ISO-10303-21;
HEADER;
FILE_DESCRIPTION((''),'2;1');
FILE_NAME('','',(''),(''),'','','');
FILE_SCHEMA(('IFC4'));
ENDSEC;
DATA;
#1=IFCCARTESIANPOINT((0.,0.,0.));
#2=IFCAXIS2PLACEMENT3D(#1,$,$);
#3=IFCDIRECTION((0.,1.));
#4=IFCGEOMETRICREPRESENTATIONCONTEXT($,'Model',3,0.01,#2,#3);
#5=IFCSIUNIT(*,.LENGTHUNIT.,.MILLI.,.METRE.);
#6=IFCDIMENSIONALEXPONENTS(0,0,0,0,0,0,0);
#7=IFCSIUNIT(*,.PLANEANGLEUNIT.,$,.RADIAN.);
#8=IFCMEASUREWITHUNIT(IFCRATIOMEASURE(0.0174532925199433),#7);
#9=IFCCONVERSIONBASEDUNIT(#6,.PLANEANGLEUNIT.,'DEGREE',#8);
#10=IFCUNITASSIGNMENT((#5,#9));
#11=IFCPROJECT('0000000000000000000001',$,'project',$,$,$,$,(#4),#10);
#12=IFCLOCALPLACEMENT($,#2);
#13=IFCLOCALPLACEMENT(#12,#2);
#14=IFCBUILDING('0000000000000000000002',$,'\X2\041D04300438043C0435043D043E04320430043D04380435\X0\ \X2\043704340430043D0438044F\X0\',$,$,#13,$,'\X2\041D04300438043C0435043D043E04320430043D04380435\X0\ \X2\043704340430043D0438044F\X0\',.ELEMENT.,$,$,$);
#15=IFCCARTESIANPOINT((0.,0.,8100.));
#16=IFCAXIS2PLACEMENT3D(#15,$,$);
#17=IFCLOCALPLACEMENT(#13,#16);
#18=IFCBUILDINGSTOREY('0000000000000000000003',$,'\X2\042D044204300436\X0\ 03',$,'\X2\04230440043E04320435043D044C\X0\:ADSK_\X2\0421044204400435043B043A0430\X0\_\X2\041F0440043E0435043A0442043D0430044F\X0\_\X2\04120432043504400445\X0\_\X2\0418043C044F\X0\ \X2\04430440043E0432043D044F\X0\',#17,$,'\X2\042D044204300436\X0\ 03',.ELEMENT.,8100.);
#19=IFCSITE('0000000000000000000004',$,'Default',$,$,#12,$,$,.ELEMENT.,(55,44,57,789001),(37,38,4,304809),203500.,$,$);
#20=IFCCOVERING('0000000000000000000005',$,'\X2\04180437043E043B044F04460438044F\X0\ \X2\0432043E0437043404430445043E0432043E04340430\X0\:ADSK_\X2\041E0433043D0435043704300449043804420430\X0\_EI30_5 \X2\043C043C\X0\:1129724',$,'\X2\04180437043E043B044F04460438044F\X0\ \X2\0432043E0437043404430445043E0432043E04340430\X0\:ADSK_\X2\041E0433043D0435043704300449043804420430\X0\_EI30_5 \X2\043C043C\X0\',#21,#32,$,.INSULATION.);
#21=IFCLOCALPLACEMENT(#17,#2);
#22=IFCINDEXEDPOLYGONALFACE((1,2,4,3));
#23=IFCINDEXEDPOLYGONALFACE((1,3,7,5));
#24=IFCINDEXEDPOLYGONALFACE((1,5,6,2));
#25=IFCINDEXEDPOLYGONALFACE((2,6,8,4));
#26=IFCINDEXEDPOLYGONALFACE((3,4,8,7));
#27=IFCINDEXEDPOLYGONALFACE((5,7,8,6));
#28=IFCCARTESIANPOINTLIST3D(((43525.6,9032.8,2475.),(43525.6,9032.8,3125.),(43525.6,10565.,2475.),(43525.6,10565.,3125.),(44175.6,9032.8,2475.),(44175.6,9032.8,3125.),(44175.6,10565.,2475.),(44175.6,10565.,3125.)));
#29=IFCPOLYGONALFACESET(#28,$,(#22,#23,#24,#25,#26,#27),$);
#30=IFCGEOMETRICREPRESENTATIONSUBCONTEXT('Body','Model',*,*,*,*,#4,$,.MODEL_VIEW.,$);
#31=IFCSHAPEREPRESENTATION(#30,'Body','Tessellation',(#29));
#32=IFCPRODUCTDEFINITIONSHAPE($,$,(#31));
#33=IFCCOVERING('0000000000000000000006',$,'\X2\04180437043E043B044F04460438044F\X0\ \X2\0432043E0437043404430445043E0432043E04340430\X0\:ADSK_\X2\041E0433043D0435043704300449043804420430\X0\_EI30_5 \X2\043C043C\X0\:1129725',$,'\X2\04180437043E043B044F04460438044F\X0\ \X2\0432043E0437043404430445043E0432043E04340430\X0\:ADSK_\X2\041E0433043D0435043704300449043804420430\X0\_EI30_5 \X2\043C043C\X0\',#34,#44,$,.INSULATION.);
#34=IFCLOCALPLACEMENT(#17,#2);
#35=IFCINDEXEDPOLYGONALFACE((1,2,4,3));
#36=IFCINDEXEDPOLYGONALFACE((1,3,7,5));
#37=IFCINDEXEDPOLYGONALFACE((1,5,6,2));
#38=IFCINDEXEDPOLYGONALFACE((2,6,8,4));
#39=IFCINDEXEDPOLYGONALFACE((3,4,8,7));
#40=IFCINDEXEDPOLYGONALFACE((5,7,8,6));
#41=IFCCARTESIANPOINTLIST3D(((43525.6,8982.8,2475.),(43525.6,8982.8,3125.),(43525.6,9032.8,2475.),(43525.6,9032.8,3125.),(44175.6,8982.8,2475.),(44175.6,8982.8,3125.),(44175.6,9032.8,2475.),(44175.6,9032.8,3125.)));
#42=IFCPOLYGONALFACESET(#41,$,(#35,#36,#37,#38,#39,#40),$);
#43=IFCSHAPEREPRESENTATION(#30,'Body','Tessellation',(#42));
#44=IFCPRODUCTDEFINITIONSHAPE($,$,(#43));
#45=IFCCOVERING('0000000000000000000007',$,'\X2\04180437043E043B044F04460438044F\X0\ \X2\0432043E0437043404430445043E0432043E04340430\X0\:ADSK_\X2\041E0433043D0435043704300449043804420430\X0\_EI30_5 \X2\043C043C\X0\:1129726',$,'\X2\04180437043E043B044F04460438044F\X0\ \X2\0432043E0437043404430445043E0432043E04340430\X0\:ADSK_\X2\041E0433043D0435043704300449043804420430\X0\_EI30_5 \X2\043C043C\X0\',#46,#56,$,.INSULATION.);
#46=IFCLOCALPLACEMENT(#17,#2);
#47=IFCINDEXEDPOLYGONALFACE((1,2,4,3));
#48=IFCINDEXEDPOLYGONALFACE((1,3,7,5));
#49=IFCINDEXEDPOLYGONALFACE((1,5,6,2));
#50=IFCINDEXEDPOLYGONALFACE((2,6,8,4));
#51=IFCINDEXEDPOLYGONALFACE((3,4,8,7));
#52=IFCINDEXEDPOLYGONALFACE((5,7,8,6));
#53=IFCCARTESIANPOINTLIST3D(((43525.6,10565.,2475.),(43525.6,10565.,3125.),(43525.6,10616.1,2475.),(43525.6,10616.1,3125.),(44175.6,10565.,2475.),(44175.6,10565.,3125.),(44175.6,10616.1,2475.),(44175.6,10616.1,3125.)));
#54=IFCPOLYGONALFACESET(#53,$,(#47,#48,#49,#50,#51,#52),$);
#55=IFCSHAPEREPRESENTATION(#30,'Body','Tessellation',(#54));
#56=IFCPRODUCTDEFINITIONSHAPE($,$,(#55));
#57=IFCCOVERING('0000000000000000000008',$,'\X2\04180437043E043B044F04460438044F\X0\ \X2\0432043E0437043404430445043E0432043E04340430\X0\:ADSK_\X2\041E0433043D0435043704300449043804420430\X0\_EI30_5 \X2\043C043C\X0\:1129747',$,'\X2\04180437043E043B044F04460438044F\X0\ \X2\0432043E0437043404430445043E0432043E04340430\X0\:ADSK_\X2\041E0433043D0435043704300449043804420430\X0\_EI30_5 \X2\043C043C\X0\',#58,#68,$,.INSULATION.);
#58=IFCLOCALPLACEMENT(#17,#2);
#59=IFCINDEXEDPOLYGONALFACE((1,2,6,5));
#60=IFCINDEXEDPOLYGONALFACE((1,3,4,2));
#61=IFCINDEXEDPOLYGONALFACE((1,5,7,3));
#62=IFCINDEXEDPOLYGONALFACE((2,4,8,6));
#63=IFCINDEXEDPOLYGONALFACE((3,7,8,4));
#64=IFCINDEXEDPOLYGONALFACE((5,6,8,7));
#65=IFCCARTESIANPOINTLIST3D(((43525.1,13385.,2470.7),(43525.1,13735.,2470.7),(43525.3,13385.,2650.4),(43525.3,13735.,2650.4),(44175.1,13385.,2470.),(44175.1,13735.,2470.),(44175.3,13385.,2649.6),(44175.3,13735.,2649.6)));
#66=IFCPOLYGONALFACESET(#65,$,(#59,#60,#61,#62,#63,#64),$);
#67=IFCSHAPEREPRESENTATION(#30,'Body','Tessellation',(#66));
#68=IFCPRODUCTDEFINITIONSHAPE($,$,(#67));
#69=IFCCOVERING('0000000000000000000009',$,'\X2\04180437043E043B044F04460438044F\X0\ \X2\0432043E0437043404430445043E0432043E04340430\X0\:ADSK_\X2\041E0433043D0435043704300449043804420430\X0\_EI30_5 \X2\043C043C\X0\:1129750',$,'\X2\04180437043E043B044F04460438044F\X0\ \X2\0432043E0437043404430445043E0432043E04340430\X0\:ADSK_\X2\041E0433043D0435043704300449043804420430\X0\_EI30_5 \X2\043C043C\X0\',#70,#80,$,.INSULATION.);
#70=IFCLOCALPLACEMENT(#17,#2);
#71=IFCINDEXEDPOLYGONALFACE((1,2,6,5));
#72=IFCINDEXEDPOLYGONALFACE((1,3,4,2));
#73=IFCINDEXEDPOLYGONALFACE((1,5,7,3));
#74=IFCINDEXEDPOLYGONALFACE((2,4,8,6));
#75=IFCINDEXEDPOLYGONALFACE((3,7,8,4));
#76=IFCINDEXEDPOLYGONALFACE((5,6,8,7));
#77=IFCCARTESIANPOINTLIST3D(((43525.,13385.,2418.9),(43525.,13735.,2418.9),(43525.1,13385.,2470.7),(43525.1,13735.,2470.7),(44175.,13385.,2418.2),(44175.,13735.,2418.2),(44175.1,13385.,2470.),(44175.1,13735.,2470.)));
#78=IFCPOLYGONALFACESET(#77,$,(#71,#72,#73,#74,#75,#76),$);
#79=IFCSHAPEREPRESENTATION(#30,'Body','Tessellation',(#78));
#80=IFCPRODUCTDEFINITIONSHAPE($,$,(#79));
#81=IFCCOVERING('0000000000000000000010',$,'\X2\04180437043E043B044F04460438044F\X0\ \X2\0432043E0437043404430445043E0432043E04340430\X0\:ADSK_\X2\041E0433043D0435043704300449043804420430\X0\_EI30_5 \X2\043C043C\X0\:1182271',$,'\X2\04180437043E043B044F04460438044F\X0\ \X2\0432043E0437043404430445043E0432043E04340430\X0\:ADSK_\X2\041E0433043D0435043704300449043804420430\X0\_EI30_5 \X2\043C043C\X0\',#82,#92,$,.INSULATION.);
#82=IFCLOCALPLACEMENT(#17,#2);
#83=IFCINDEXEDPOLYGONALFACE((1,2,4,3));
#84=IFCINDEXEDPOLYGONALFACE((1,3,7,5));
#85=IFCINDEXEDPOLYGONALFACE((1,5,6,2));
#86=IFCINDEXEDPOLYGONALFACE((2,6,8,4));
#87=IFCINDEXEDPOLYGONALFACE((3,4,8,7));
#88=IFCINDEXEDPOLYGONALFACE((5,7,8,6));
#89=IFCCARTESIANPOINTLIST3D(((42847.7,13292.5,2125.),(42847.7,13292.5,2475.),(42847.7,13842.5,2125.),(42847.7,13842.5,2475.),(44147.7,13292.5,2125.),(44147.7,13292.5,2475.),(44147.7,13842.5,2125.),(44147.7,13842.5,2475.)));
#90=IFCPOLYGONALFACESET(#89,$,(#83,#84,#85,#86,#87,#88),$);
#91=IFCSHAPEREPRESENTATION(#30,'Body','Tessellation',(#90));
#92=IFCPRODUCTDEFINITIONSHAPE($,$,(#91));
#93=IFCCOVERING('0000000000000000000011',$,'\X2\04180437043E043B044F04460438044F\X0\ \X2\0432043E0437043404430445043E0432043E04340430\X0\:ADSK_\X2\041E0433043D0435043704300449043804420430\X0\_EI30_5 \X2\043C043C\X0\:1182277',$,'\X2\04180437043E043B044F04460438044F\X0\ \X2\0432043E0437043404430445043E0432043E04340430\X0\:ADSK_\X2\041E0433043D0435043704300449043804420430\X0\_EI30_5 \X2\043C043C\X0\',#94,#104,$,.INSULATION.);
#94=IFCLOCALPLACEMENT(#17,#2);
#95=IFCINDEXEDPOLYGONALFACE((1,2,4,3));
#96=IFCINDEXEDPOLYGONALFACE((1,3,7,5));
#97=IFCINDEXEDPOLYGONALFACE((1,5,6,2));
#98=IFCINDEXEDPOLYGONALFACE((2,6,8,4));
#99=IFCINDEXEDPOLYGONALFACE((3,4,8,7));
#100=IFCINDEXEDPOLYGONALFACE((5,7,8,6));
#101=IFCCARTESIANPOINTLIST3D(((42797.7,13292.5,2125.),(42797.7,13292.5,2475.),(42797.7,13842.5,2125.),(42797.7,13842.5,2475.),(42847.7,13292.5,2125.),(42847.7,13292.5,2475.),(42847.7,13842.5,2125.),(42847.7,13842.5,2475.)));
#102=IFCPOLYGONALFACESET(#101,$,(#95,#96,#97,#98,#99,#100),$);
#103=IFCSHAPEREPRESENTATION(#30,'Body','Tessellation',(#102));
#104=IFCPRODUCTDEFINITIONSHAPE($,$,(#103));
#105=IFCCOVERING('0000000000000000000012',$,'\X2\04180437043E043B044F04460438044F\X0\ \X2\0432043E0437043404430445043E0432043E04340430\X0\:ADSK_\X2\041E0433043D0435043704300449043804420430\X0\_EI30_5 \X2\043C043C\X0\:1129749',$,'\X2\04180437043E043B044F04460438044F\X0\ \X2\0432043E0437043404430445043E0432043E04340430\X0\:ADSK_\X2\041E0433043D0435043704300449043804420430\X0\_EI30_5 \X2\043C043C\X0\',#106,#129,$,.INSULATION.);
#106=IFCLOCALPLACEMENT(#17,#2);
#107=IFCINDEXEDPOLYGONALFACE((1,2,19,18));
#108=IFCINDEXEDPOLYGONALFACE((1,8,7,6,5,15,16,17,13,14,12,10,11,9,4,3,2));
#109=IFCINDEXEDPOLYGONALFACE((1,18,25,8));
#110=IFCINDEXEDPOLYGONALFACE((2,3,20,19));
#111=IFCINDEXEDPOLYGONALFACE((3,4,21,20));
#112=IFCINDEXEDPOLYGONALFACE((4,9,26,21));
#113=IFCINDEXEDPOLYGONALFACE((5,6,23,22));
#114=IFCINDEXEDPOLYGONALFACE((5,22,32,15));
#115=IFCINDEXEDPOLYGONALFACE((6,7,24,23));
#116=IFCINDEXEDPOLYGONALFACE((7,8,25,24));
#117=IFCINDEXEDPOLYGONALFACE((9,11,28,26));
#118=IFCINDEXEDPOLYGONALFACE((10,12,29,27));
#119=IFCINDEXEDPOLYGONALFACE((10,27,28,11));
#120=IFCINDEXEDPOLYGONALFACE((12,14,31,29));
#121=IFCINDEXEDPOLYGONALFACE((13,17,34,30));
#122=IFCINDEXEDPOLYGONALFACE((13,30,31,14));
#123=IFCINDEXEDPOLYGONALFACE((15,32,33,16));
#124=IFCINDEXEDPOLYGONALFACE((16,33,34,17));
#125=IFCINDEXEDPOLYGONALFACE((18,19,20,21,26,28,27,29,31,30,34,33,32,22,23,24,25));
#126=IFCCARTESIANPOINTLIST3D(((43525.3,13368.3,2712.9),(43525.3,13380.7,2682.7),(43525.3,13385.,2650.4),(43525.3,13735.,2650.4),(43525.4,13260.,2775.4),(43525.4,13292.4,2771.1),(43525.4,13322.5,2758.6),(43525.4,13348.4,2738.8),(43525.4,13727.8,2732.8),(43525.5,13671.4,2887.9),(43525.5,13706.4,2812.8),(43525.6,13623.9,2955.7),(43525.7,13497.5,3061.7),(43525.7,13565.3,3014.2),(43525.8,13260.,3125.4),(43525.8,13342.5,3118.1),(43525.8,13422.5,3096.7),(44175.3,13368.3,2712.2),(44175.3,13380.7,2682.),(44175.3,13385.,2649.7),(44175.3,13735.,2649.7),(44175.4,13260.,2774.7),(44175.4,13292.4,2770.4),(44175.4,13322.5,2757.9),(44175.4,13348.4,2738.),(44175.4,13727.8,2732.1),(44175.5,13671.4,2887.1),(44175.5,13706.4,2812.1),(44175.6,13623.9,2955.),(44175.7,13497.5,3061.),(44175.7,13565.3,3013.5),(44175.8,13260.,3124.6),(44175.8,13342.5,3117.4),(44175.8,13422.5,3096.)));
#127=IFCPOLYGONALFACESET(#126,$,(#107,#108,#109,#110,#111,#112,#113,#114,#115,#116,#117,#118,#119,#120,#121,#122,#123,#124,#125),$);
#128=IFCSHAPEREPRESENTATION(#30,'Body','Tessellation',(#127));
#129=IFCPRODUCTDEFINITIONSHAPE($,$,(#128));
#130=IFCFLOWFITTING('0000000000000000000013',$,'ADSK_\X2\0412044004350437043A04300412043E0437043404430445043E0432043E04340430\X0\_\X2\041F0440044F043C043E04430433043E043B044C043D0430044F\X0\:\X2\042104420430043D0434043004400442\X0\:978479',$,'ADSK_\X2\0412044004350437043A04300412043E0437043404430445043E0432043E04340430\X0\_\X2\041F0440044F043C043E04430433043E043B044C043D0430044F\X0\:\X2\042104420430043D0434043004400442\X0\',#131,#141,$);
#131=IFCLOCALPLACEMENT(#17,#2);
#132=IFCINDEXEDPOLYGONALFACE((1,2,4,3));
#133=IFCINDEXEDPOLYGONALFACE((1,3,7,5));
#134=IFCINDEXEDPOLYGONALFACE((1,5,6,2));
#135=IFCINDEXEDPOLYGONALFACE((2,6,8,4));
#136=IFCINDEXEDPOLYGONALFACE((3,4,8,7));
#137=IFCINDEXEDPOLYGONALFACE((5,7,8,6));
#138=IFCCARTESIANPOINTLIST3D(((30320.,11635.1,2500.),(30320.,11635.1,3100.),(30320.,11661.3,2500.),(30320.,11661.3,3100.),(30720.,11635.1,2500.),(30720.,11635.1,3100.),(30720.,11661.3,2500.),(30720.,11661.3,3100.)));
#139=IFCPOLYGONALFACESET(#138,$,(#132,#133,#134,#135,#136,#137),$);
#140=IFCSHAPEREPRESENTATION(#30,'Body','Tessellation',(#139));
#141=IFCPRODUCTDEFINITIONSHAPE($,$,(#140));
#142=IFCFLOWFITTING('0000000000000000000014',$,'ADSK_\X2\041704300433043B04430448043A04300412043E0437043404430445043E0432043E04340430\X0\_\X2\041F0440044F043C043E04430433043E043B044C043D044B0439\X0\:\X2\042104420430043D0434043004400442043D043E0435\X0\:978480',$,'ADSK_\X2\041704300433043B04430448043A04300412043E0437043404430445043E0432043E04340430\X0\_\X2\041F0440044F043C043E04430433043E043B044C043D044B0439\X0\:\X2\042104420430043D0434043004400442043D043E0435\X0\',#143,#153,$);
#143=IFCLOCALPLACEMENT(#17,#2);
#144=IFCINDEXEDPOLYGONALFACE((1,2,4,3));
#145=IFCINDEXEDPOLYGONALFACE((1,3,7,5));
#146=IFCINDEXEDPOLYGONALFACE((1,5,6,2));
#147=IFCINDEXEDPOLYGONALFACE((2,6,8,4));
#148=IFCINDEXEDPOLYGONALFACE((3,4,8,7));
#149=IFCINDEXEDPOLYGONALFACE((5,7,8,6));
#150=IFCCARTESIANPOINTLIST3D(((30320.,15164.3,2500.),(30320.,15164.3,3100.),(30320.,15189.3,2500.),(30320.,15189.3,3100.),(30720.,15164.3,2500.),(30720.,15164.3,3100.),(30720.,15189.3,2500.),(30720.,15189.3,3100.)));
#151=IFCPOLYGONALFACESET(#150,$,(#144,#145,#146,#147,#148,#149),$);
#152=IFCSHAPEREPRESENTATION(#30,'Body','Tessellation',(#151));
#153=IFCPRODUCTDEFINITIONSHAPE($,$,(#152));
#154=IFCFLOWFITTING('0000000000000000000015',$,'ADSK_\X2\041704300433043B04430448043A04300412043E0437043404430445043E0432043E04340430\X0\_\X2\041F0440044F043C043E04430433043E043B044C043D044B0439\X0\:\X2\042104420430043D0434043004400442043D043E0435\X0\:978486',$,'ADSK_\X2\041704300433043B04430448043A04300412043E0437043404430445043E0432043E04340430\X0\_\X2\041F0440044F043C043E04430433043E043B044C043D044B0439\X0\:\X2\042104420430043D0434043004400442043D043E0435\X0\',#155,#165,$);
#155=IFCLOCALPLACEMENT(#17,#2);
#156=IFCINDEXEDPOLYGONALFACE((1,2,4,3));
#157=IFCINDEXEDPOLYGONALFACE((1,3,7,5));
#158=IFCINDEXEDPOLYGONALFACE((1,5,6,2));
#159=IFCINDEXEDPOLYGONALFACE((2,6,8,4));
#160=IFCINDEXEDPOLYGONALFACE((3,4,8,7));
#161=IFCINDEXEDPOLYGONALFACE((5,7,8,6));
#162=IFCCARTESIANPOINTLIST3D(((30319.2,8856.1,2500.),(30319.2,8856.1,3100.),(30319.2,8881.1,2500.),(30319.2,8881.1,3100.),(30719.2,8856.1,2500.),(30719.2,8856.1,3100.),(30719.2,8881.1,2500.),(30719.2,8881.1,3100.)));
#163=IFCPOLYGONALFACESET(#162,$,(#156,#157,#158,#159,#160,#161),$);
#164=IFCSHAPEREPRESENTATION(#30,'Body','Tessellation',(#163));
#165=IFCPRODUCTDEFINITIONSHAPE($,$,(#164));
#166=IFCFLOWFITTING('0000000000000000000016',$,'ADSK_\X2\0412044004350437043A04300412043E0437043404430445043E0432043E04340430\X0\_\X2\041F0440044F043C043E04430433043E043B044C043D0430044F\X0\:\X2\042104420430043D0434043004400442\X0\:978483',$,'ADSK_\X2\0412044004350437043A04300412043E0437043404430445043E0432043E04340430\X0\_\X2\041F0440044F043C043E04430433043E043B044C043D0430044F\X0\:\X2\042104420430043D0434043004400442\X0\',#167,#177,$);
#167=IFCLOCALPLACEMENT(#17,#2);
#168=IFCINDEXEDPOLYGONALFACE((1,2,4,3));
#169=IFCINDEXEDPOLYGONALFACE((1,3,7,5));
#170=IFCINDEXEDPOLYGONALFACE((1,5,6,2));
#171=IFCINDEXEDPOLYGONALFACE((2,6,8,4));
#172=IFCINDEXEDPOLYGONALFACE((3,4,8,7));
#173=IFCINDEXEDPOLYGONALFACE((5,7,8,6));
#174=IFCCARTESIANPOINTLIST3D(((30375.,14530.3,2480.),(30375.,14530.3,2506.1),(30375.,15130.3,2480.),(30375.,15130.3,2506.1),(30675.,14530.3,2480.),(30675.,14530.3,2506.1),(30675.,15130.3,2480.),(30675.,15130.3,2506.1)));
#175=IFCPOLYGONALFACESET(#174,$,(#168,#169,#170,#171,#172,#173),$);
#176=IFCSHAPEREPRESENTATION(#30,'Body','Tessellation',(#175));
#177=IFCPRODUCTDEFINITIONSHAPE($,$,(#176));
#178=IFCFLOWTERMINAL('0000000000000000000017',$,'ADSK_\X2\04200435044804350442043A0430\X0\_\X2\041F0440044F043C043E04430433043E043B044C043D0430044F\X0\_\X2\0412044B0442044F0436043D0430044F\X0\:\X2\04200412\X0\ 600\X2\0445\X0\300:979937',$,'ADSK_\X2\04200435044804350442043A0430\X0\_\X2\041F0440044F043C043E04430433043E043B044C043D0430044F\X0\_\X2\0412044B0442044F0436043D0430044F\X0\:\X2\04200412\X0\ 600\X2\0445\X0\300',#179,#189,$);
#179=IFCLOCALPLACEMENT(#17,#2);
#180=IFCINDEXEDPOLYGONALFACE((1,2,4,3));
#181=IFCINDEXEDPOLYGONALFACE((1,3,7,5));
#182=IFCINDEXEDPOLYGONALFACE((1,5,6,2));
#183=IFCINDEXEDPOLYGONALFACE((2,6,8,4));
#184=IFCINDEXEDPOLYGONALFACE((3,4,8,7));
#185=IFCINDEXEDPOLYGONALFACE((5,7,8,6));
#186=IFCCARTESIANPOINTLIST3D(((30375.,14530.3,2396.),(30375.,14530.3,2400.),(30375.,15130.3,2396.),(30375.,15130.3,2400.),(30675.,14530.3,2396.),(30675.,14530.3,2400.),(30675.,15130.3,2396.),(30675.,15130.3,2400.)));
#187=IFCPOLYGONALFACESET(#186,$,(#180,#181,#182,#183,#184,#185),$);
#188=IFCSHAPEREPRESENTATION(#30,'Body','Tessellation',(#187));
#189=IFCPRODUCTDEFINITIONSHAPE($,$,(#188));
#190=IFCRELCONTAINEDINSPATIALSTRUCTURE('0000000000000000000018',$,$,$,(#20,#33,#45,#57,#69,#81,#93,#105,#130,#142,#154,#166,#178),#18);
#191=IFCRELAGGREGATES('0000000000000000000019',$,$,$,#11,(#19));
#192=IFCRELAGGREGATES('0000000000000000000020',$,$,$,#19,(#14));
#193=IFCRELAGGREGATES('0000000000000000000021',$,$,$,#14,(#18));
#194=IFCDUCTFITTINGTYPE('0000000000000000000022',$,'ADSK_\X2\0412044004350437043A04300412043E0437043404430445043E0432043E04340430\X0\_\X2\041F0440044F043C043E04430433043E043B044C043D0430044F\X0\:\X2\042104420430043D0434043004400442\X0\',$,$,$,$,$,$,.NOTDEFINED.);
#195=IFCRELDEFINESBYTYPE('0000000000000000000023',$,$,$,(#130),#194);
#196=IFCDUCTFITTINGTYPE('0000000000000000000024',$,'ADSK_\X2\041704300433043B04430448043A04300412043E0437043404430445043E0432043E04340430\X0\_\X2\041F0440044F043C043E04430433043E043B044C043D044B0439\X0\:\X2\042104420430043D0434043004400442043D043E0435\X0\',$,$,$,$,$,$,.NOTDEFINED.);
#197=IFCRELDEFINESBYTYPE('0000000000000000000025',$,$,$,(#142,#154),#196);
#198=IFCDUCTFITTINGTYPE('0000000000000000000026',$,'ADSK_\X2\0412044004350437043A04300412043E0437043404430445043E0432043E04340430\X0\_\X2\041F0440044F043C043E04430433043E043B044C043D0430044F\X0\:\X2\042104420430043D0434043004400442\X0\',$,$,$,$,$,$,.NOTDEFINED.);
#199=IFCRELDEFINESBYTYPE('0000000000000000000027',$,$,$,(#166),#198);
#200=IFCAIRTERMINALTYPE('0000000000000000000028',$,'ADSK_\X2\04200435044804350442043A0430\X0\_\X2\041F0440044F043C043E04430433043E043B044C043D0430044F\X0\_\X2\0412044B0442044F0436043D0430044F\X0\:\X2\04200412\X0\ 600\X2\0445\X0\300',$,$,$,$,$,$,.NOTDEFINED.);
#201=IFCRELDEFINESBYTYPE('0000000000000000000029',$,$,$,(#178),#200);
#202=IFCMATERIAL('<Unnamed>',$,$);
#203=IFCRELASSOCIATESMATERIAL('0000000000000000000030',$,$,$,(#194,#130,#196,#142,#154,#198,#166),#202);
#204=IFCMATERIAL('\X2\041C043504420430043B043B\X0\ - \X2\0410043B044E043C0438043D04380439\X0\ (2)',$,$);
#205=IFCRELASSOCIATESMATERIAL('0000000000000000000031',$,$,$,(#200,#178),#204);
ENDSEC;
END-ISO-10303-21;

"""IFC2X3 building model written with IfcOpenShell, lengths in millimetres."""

from ifc_helpers import new_model, entity, si_unit, converted_unit, direction, frame, frame_2d, origin, origin_2d_with_axis, place, context, subcontext, project, spatial, polyline, circle_curve, parameter, trimmed, segment, composite_curve, rectangle, outline, extrude, source, transform, mapped, material, type_object, type_shapes, element, save


model = new_model("IFC2X3")

# Units and contexts
model_context = context("Model", 3, precision=0.01, world=origin(), true_north=direction((0.0, 1.0)))
body_context = subcontext(model_context, "Body", "Model", "MODEL_VIEW")
ifc_project = project(units=[si_unit("LENGTHUNIT", "METRE", prefix="MILLI"), converted_unit("PLANEANGLEUNIT", "DEGREE", entity("IfcRatioMeasure", 0.0174532925199433), si_unit("PLANEANGLEUNIT", "RADIAN"), dimensions=[0, 0, 0, 0, 0, 0, 0])], contexts=[model_context])

# Site, building, storey
site_placement = place(None, origin())
site = spatial("IfcSite", under=ifc_project, at=site_placement, Name="Default", CompositionType="ELEMENT", RefLatitude=(55, 44, 57, 789001), RefLongitude=(37, 38, 4, 304809), RefElevation=203500.0)
building_placement = place(site_placement, origin())
building = spatial("IfcBuilding", under=site, at=building_placement, Name="Наименование здания", LongName="Наименование здания", CompositionType="ELEMENT")
storey_placement = place(building_placement, frame((0.0, 0.0, 8100.0)))
storey = spatial("IfcBuildingStorey", under=building, at=storey_placement, Name="Этаж 03", ObjectType="Уровень:ADSK_Стрелка_Проектная_Вверх_Имя уровня", LongName="Этаж 03", CompositionType="ELEMENT", Elevation=8100.0)

# Coverings
covering_1_placement = place(storey_placement, frame((43525.6, 9032.8, 2475.0)))
element("IfcCovering", 1, at=covering_1_placement, inside=storey, Name="Изоляция воздуховода:ADSK_Огнезащита_EI30_5 мм:1129724", ObjectType="Изоляция воздуховода:ADSK_Огнезащита_EI30_5 мм", PredefinedType="INSULATION", context=body_context, shape_type="SweptSolid", body=[
    extrude(rectangle(XDim=1532.2, YDim=650.0, at=origin_2d_with_axis()), frame((325.0, 766.1, 0.0), z_axis=(0.0, 0.0, 1.0), x_axis=(0.0, 1.0, 0.0)), (0.0, 0.0, 1.0), 650.0),
])
covering_2_placement = place(storey_placement, frame((43525.6, 8982.8, 2475.0)))
element("IfcCovering", 2, at=covering_2_placement, inside=storey, Name="Изоляция воздуховода:ADSK_Огнезащита_EI30_5 мм:1129725", ObjectType="Изоляция воздуховода:ADSK_Огнезащита_EI30_5 мм", PredefinedType="INSULATION", context=body_context, shape_type="SweptSolid", body=[
    extrude(rectangle(XDim=50.0, YDim=650.0, at=origin_2d_with_axis()), frame((325.0, 25.0, 0.0), z_axis=(0.0, 0.0, 1.0), x_axis=(0.0, 1.0, 0.0)), (0.0, 0.0, 1.0), 650.0),
])
covering_3_placement = place(storey_placement, frame((43525.6, 10565.0, 2475.0)))
element("IfcCovering", 3, at=covering_3_placement, inside=storey, Name="Изоляция воздуховода:ADSK_Огнезащита_EI30_5 мм:1129726", ObjectType="Изоляция воздуховода:ADSK_Огнезащита_EI30_5 мм", PredefinedType="INSULATION", context=body_context, shape_type="SweptSolid", body=[
    extrude(rectangle(XDim=650.0, YDim=51.1, at=origin_2d_with_axis()), frame((325.0, 25.6, 0.0)), (0.0, 0.0, 1.0), 650.0),
])
covering_4_placement = place(storey_placement, frame((43525.1, 13385.0, 2470.0)))
element("IfcCovering", 4, at=covering_4_placement, inside=storey, Name="Изоляция воздуховода:ADSK_Огнезащита_EI30_5 мм:1129747", ObjectType="Изоляция воздуховода:ADSK_Огнезащита_EI30_5 мм", PredefinedType="INSULATION", context=body_context, shape_type="SweptSolid", body=[
    extrude(rectangle(XDim=650.0, YDim=350.0, at=origin_2d_with_axis()), frame((325.0, 175.0, 0.4), z_axis=(0.0011, 0.0, 0.999999), x_axis=(-0.999999, 0.0, 0.0011)), (0.0, 0.0, 1.0), 179.7),
])
covering_5_placement = place(storey_placement, frame((43525.0, 13385.0, 2418.2)))
element("IfcCovering", 5, at=covering_5_placement, inside=storey, Name="Изоляция воздуховода:ADSK_Огнезащита_EI30_5 мм:1129750", ObjectType="Изоляция воздуховода:ADSK_Огнезащита_EI30_5 мм", PredefinedType="INSULATION", context=body_context, shape_type="SweptSolid", body=[
    extrude(rectangle(XDim=650.0, YDim=350.0, at=frame_2d((0.0, 0.0), x_axis=(0.0, 1.0))), frame((325.0, 175.0, 0.4), z_axis=(0.0011, 0.0, 0.999999), x_axis=(0.0, -1.0, 0.0)), (0.0, 0.0, 1.0), 51.8),
])
covering_6_placement = place(storey_placement, frame((42847.7, 13292.5, 2125.0)))
element("IfcCovering", 6, at=covering_6_placement, inside=storey, Name="Изоляция воздуховода:ADSK_Огнезащита_EI30_5 мм:1182271", ObjectType="Изоляция воздуховода:ADSK_Огнезащита_EI30_5 мм", PredefinedType="INSULATION", context=body_context, shape_type="SweptSolid", body=[
    extrude(rectangle(XDim=1300.0, YDim=550.0, at=origin_2d_with_axis()), frame((650.0, 275.0, 0.0), z_axis=(0.0, 0.0, 1.0), x_axis=(-1.0, 0.0, 0.0)), (0.0, 0.0, 1.0), 350.0),
])
covering_7_placement = place(storey_placement, frame((42797.7, 13292.5, 2125.0)))
element("IfcCovering", 7, at=covering_7_placement, inside=storey, Name="Изоляция воздуховода:ADSK_Огнезащита_EI30_5 мм:1182277", ObjectType="Изоляция воздуховода:ADSK_Огнезащита_EI30_5 мм", PredefinedType="INSULATION", context=body_context, shape_type="SweptSolid", body=[
    extrude(rectangle(XDim=50.0, YDim=550.0, at=origin_2d_with_axis()), frame((25.0, 275.0, 0.0)), (0.0, 0.0, 1.0), 350.0),
])
covering_8_placement = place(storey_placement, frame((43523.7, 13258.4, 2648.1)))
element("IfcCovering", 8, at=covering_8_placement, inside=storey, Name="Изоляция воздуховода:ADSK_Огнезащита_EI30_5 мм:1129749", ObjectType="Изоляция воздуховода:ADSK_Огнезащита_EI30_5 мм", PredefinedType="INSULATION", context=body_context, shape_type="SweptSolid", body=[
    extrude(outline(composite_curve([segment(polyline([(-150.0, 25.0), (-150.0, -325.0)]), True, "CONTINUOUS"), segment(trimmed(circle_curve(frame_2d((-150.0, 150.0), x_axis=(1.0, 0.0)), 475.0), [parameter(270.0)], [parameter(0.0)], True, "PARAMETER"), True, "CONTINUOUS"), segment(polyline([(325.0, 150.0), (-25.0, 150.0)]), True, "CONTINUOUS"), segment(trimmed(circle_curve(frame_2d((-150.0, 150.0), x_axis=(1.0, 0.0)), 125.0), [parameter(270.0)], [parameter(360.0)], True, "PARAMETER"), False, "CONTINUOUS")], self_intersect=False)), frame((651.8, 151.6, 151.6), z_axis=(0.999999, 0.0, -0.0011), x_axis=(0.0011, 0.0, 0.999999)), (0.0, 0.0, -1.0), 650.0),
])

# Flow fittings
ifc_material_1 = material(Name="<Unnamed>")
duct_fitting_type_1 = type_object("IfcDuctFittingType", Name="ADSK_ВрезкаВоздуховода_Прямоугольная:Стандарт", PredefinedType="NOTDEFINED", material=ifc_material_1)
shared_shape_1 = source(origin(), body_context, "Body", "SweptSolid", [
    extrude(rectangle(XDim=26.2, YDim=600.0, at=origin_2d_with_axis()), frame((7.0, 0.0, -200.0)), (0.0, 0.0, 1.0), 400.0),
])
type_shapes(duct_fitting_type_1, [shared_shape_1])
flow_fitting_1_placement = place(storey_placement, frame((30520.0, 11641.2, 2800.0), z_axis=(1.0, 0.0, 0.0), x_axis=(0.0, 1.0, 0.0)))
element("IfcFlowFitting", 9, at=flow_fitting_1_placement, inside=storey, type_object=duct_fitting_type_1, material=ifc_material_1, Name="ADSK_ВрезкаВоздуховода_Прямоугольная:Стандарт:978479", ObjectType="ADSK_ВрезкаВоздуховода_Прямоугольная:Стандарт", context=body_context, shape_type="MappedRepresentation", body=[
    mapped(shared_shape_1, transform((0.0, 0.0, 0.0), scale=1.0)),
])
duct_fitting_type_2 = type_object("IfcDuctFittingType", Name="ADSK_ЗаглушкаВоздуховода_Прямоугольный:Стандартное", PredefinedType="NOTDEFINED", material=ifc_material_1)
shared_shape_2 = source(origin(), body_context, "Body", "SweptSolid", [
    extrude(rectangle(XDim=25.0, YDim=400.0, at=origin_2d_with_axis()), frame((12.5, 0.0, -300.0)), (0.0, 0.0, 1.0), 600.0),
])
type_shapes(duct_fitting_type_2, [shared_shape_2])
for number, where, z_axis, x_axis, name in (
    (10, (30520.0, 15164.3, 2800.0), (0.0, 0.0, 1.0), (0.0, 1.0, 0.0), "ADSK_ЗаглушкаВоздуховода_Прямоугольный:Стандартное:978480"),
    (11, (30519.2, 8881.1, 2800.0), (0.0, 0.0, 1.0), (0.0, -1.0, 0.0), "ADSK_ЗаглушкаВоздуховода_Прямоугольный:Стандартное:978486"),
):
    element("IfcFlowFitting", number, at=place(storey_placement, frame(where, z_axis=z_axis, x_axis=x_axis)), inside=storey, type_object=duct_fitting_type_2, material=ifc_material_1, Name=name, ObjectType="ADSK_ЗаглушкаВоздуховода_Прямоугольный:Стандартное", context=body_context, shape_type="MappedRepresentation", body=[
        mapped(shared_shape_2, transform((0.0, 0.0, 0.0), scale=1.0)),
    ])
duct_fitting_type_3 = type_object("IfcDuctFittingType", Name="ADSK_ВрезкаВоздуховода_Прямоугольная:Стандарт", PredefinedType="NOTDEFINED", material=ifc_material_1)
shared_shape_3 = source(origin(), body_context, "Body", "SweptSolid", [
    extrude(rectangle(XDim=26.1, YDim=600.0, at=origin_2d_with_axis()), frame((7.0, 0.0, -150.0)), (0.0, 0.0, 1.0), 300.0),
])
type_shapes(duct_fitting_type_3, [shared_shape_3])
flow_fitting_2_placement = place(storey_placement, frame((30525.0, 14830.3, 2500.0), z_axis=(-1.0, 0.0, 0.0), x_axis=(0.0, 0.0, -1.0)))
element("IfcFlowFitting", 12, at=flow_fitting_2_placement, inside=storey, type_object=duct_fitting_type_3, material=ifc_material_1, Name="ADSK_ВрезкаВоздуховода_Прямоугольная:Стандарт:978483", ObjectType="ADSK_ВрезкаВоздуховода_Прямоугольная:Стандарт", context=body_context, shape_type="MappedRepresentation", body=[
    mapped(shared_shape_3, transform((0.0, 0.0, 0.0), scale=1.0)),
])

# Flow terminal
ifc_material_2 = material(Name="Металл - Алюминий (2)")
air_terminal_type = type_object("IfcAirTerminalType", Name="ADSK_Решетка_Прямоугольная_Вытяжная:РВ 600х300", PredefinedType="NOTDEFINED", material=ifc_material_2)
shared_shape_4 = source(origin(), body_context, "Body", "SweptSolid", [
    extrude(rectangle(XDim=4.0, YDim=600.0, at=origin_2d_with_axis()), frame((0.0, -2.0, -150.0), z_axis=(0.0, 0.0, 1.0), x_axis=(0.0, 1.0, 0.0)), (0.0, 0.0, 1.0), 300.0),
])
type_shapes(air_terminal_type, [shared_shape_4])
flow_terminal_placement = place(storey_placement, frame((30525.0, 14830.3, 2400.0), z_axis=(-1.0, 0.0, 0.0), x_axis=(0.0, -1.0, 0.0)))
element("IfcFlowTerminal", 13, at=flow_terminal_placement, inside=storey, type_object=air_terminal_type, material=ifc_material_2, Name="ADSK_Решетка_Прямоугольная_Вытяжная:РВ 600х300:979937", ObjectType="ADSK_Решетка_Прямоугольная_Вытяжная:РВ 600х300", context=body_context, shape_type="MappedRepresentation", body=[
    mapped(shared_shape_4, transform((0.0, 0.0, 0.0), scale=1.0)),
])

save(model, "model.ifc")
